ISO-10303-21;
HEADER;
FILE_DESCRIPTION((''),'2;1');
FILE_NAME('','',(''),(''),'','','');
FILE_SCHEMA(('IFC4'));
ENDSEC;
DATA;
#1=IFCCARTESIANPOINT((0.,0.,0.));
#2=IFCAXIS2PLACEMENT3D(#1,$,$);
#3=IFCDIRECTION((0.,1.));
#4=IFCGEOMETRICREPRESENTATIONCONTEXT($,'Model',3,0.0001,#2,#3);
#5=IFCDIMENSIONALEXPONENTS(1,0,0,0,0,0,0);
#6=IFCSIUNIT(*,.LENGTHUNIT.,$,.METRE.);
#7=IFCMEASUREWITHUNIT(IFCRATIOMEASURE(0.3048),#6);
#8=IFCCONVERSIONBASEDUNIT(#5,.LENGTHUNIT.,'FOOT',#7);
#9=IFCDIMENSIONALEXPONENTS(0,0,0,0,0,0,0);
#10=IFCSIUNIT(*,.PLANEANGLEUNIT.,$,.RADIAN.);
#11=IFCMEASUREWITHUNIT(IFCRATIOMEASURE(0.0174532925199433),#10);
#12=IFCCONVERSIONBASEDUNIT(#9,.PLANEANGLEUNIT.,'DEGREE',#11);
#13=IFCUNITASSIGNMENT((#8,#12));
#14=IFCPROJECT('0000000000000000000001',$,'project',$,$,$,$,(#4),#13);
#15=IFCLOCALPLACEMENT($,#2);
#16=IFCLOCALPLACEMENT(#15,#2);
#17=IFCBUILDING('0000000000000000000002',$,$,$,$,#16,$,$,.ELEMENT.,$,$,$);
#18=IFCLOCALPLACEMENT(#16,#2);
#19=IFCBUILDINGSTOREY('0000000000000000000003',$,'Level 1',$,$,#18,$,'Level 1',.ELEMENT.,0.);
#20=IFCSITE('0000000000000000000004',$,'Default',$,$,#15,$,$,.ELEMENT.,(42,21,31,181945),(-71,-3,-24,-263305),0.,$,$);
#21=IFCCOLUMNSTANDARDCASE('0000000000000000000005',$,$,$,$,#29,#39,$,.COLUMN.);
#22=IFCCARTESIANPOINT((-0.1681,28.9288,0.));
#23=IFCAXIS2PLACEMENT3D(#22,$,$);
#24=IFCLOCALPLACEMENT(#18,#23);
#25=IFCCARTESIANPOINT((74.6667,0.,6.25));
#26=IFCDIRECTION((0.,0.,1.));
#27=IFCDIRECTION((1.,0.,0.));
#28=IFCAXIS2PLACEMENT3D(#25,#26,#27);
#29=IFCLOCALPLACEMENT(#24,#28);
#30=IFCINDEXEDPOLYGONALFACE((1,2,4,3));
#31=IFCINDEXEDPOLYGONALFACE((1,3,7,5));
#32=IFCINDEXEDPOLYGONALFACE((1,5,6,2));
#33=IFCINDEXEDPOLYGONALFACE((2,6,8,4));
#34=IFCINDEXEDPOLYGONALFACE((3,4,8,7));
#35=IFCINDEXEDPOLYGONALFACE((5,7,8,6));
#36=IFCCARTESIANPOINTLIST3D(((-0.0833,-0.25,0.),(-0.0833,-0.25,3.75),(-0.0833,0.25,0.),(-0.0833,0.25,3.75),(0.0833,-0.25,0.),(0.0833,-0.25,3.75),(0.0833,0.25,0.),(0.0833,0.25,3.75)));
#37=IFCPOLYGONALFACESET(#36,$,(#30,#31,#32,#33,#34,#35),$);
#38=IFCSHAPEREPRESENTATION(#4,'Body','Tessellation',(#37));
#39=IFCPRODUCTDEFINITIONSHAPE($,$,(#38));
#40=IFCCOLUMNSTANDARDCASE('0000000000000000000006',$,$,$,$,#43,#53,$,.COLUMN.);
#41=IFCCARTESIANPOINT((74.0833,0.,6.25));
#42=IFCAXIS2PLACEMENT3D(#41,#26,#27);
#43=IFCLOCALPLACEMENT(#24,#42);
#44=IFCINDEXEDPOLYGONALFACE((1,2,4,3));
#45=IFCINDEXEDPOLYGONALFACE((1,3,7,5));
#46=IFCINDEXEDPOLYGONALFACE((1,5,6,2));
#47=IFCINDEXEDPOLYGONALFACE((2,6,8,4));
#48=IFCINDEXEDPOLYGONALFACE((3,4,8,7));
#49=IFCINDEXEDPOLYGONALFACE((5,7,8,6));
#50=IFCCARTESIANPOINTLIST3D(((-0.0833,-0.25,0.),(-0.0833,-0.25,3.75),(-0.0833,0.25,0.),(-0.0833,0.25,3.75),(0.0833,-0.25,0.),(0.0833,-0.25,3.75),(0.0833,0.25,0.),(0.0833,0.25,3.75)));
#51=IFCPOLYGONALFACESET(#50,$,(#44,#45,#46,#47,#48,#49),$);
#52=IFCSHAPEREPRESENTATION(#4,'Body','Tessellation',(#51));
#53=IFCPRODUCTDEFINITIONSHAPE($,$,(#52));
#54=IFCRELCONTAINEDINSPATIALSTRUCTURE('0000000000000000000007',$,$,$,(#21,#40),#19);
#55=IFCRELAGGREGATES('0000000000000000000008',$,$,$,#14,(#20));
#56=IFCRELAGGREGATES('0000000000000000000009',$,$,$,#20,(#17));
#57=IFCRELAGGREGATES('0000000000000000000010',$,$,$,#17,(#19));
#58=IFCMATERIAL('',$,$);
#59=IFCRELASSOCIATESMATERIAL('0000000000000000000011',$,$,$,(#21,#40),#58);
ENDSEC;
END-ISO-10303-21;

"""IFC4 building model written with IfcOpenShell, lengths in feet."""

from ifc_helpers import new_model, entity, si_unit, converted_unit, direction, frame, origin, place, context, project, spatial, rectangle, extrude, material, element, save


model = new_model("IFC4")

# Units and contexts
model_context = context("Model", 3, precision=0.0001, world=origin(), true_north=direction((0.0, 1.0)))
ifc_project = project(units=[converted_unit("LENGTHUNIT", "FOOT", entity("IfcRatioMeasure", 0.3048), si_unit("LENGTHUNIT", "METRE"), dimensions=[1, 0, 0, 0, 0, 0, 0]), converted_unit("PLANEANGLEUNIT", "DEGREE", entity("IfcRatioMeasure", 0.0174532925199433), si_unit("PLANEANGLEUNIT", "RADIAN"), dimensions=[0, 0, 0, 0, 0, 0, 0])], contexts=[model_context])

# Site, building, storey
site_placement = place(None, origin())
site = spatial("IfcSite", under=ifc_project, at=site_placement, Name="Default", CompositionType="ELEMENT", RefLatitude=(42, 21, 31, 181945), RefLongitude=(-71, -3, -24, -263305), RefElevation=0.0)
building_placement = place(site_placement, origin())
building = spatial("IfcBuilding", under=site, at=building_placement, CompositionType="ELEMENT")
storey_placement = place(building_placement, origin())
storey = spatial("IfcBuildingStorey", under=building, at=storey_placement, Name="Level 1", LongName="Level 1", CompositionType="ELEMENT", Elevation=0.0)

# Columns
ifc_material_1 = material(Name="")
placement = place(storey_placement, frame((-0.1681, 28.9288, 0.0)))
for number, where, z_axis, x_axis in (
    (1, (74.6667, 0.0, 6.25), (0.0, 0.0, 1.0), (1.0, 0.0, 0.0)),
    (2, (74.0833, 0.0, 6.25), (0.0, 0.0, 1.0), (1.0, 0.0, 0.0)),
):
    element("IfcColumnStandardCase", number, at=place(placement, frame(where, z_axis=z_axis, x_axis=x_axis)), inside=storey, material=ifc_material_1, PredefinedType="COLUMN", context=model_context, shape_type="SweptSolid", body=[
        extrude(rectangle(XDim=0.1667, YDim=0.5), origin(), (0.0, 0.0, 1.0), 3.75),
    ])

save(model, "model.ifc")
